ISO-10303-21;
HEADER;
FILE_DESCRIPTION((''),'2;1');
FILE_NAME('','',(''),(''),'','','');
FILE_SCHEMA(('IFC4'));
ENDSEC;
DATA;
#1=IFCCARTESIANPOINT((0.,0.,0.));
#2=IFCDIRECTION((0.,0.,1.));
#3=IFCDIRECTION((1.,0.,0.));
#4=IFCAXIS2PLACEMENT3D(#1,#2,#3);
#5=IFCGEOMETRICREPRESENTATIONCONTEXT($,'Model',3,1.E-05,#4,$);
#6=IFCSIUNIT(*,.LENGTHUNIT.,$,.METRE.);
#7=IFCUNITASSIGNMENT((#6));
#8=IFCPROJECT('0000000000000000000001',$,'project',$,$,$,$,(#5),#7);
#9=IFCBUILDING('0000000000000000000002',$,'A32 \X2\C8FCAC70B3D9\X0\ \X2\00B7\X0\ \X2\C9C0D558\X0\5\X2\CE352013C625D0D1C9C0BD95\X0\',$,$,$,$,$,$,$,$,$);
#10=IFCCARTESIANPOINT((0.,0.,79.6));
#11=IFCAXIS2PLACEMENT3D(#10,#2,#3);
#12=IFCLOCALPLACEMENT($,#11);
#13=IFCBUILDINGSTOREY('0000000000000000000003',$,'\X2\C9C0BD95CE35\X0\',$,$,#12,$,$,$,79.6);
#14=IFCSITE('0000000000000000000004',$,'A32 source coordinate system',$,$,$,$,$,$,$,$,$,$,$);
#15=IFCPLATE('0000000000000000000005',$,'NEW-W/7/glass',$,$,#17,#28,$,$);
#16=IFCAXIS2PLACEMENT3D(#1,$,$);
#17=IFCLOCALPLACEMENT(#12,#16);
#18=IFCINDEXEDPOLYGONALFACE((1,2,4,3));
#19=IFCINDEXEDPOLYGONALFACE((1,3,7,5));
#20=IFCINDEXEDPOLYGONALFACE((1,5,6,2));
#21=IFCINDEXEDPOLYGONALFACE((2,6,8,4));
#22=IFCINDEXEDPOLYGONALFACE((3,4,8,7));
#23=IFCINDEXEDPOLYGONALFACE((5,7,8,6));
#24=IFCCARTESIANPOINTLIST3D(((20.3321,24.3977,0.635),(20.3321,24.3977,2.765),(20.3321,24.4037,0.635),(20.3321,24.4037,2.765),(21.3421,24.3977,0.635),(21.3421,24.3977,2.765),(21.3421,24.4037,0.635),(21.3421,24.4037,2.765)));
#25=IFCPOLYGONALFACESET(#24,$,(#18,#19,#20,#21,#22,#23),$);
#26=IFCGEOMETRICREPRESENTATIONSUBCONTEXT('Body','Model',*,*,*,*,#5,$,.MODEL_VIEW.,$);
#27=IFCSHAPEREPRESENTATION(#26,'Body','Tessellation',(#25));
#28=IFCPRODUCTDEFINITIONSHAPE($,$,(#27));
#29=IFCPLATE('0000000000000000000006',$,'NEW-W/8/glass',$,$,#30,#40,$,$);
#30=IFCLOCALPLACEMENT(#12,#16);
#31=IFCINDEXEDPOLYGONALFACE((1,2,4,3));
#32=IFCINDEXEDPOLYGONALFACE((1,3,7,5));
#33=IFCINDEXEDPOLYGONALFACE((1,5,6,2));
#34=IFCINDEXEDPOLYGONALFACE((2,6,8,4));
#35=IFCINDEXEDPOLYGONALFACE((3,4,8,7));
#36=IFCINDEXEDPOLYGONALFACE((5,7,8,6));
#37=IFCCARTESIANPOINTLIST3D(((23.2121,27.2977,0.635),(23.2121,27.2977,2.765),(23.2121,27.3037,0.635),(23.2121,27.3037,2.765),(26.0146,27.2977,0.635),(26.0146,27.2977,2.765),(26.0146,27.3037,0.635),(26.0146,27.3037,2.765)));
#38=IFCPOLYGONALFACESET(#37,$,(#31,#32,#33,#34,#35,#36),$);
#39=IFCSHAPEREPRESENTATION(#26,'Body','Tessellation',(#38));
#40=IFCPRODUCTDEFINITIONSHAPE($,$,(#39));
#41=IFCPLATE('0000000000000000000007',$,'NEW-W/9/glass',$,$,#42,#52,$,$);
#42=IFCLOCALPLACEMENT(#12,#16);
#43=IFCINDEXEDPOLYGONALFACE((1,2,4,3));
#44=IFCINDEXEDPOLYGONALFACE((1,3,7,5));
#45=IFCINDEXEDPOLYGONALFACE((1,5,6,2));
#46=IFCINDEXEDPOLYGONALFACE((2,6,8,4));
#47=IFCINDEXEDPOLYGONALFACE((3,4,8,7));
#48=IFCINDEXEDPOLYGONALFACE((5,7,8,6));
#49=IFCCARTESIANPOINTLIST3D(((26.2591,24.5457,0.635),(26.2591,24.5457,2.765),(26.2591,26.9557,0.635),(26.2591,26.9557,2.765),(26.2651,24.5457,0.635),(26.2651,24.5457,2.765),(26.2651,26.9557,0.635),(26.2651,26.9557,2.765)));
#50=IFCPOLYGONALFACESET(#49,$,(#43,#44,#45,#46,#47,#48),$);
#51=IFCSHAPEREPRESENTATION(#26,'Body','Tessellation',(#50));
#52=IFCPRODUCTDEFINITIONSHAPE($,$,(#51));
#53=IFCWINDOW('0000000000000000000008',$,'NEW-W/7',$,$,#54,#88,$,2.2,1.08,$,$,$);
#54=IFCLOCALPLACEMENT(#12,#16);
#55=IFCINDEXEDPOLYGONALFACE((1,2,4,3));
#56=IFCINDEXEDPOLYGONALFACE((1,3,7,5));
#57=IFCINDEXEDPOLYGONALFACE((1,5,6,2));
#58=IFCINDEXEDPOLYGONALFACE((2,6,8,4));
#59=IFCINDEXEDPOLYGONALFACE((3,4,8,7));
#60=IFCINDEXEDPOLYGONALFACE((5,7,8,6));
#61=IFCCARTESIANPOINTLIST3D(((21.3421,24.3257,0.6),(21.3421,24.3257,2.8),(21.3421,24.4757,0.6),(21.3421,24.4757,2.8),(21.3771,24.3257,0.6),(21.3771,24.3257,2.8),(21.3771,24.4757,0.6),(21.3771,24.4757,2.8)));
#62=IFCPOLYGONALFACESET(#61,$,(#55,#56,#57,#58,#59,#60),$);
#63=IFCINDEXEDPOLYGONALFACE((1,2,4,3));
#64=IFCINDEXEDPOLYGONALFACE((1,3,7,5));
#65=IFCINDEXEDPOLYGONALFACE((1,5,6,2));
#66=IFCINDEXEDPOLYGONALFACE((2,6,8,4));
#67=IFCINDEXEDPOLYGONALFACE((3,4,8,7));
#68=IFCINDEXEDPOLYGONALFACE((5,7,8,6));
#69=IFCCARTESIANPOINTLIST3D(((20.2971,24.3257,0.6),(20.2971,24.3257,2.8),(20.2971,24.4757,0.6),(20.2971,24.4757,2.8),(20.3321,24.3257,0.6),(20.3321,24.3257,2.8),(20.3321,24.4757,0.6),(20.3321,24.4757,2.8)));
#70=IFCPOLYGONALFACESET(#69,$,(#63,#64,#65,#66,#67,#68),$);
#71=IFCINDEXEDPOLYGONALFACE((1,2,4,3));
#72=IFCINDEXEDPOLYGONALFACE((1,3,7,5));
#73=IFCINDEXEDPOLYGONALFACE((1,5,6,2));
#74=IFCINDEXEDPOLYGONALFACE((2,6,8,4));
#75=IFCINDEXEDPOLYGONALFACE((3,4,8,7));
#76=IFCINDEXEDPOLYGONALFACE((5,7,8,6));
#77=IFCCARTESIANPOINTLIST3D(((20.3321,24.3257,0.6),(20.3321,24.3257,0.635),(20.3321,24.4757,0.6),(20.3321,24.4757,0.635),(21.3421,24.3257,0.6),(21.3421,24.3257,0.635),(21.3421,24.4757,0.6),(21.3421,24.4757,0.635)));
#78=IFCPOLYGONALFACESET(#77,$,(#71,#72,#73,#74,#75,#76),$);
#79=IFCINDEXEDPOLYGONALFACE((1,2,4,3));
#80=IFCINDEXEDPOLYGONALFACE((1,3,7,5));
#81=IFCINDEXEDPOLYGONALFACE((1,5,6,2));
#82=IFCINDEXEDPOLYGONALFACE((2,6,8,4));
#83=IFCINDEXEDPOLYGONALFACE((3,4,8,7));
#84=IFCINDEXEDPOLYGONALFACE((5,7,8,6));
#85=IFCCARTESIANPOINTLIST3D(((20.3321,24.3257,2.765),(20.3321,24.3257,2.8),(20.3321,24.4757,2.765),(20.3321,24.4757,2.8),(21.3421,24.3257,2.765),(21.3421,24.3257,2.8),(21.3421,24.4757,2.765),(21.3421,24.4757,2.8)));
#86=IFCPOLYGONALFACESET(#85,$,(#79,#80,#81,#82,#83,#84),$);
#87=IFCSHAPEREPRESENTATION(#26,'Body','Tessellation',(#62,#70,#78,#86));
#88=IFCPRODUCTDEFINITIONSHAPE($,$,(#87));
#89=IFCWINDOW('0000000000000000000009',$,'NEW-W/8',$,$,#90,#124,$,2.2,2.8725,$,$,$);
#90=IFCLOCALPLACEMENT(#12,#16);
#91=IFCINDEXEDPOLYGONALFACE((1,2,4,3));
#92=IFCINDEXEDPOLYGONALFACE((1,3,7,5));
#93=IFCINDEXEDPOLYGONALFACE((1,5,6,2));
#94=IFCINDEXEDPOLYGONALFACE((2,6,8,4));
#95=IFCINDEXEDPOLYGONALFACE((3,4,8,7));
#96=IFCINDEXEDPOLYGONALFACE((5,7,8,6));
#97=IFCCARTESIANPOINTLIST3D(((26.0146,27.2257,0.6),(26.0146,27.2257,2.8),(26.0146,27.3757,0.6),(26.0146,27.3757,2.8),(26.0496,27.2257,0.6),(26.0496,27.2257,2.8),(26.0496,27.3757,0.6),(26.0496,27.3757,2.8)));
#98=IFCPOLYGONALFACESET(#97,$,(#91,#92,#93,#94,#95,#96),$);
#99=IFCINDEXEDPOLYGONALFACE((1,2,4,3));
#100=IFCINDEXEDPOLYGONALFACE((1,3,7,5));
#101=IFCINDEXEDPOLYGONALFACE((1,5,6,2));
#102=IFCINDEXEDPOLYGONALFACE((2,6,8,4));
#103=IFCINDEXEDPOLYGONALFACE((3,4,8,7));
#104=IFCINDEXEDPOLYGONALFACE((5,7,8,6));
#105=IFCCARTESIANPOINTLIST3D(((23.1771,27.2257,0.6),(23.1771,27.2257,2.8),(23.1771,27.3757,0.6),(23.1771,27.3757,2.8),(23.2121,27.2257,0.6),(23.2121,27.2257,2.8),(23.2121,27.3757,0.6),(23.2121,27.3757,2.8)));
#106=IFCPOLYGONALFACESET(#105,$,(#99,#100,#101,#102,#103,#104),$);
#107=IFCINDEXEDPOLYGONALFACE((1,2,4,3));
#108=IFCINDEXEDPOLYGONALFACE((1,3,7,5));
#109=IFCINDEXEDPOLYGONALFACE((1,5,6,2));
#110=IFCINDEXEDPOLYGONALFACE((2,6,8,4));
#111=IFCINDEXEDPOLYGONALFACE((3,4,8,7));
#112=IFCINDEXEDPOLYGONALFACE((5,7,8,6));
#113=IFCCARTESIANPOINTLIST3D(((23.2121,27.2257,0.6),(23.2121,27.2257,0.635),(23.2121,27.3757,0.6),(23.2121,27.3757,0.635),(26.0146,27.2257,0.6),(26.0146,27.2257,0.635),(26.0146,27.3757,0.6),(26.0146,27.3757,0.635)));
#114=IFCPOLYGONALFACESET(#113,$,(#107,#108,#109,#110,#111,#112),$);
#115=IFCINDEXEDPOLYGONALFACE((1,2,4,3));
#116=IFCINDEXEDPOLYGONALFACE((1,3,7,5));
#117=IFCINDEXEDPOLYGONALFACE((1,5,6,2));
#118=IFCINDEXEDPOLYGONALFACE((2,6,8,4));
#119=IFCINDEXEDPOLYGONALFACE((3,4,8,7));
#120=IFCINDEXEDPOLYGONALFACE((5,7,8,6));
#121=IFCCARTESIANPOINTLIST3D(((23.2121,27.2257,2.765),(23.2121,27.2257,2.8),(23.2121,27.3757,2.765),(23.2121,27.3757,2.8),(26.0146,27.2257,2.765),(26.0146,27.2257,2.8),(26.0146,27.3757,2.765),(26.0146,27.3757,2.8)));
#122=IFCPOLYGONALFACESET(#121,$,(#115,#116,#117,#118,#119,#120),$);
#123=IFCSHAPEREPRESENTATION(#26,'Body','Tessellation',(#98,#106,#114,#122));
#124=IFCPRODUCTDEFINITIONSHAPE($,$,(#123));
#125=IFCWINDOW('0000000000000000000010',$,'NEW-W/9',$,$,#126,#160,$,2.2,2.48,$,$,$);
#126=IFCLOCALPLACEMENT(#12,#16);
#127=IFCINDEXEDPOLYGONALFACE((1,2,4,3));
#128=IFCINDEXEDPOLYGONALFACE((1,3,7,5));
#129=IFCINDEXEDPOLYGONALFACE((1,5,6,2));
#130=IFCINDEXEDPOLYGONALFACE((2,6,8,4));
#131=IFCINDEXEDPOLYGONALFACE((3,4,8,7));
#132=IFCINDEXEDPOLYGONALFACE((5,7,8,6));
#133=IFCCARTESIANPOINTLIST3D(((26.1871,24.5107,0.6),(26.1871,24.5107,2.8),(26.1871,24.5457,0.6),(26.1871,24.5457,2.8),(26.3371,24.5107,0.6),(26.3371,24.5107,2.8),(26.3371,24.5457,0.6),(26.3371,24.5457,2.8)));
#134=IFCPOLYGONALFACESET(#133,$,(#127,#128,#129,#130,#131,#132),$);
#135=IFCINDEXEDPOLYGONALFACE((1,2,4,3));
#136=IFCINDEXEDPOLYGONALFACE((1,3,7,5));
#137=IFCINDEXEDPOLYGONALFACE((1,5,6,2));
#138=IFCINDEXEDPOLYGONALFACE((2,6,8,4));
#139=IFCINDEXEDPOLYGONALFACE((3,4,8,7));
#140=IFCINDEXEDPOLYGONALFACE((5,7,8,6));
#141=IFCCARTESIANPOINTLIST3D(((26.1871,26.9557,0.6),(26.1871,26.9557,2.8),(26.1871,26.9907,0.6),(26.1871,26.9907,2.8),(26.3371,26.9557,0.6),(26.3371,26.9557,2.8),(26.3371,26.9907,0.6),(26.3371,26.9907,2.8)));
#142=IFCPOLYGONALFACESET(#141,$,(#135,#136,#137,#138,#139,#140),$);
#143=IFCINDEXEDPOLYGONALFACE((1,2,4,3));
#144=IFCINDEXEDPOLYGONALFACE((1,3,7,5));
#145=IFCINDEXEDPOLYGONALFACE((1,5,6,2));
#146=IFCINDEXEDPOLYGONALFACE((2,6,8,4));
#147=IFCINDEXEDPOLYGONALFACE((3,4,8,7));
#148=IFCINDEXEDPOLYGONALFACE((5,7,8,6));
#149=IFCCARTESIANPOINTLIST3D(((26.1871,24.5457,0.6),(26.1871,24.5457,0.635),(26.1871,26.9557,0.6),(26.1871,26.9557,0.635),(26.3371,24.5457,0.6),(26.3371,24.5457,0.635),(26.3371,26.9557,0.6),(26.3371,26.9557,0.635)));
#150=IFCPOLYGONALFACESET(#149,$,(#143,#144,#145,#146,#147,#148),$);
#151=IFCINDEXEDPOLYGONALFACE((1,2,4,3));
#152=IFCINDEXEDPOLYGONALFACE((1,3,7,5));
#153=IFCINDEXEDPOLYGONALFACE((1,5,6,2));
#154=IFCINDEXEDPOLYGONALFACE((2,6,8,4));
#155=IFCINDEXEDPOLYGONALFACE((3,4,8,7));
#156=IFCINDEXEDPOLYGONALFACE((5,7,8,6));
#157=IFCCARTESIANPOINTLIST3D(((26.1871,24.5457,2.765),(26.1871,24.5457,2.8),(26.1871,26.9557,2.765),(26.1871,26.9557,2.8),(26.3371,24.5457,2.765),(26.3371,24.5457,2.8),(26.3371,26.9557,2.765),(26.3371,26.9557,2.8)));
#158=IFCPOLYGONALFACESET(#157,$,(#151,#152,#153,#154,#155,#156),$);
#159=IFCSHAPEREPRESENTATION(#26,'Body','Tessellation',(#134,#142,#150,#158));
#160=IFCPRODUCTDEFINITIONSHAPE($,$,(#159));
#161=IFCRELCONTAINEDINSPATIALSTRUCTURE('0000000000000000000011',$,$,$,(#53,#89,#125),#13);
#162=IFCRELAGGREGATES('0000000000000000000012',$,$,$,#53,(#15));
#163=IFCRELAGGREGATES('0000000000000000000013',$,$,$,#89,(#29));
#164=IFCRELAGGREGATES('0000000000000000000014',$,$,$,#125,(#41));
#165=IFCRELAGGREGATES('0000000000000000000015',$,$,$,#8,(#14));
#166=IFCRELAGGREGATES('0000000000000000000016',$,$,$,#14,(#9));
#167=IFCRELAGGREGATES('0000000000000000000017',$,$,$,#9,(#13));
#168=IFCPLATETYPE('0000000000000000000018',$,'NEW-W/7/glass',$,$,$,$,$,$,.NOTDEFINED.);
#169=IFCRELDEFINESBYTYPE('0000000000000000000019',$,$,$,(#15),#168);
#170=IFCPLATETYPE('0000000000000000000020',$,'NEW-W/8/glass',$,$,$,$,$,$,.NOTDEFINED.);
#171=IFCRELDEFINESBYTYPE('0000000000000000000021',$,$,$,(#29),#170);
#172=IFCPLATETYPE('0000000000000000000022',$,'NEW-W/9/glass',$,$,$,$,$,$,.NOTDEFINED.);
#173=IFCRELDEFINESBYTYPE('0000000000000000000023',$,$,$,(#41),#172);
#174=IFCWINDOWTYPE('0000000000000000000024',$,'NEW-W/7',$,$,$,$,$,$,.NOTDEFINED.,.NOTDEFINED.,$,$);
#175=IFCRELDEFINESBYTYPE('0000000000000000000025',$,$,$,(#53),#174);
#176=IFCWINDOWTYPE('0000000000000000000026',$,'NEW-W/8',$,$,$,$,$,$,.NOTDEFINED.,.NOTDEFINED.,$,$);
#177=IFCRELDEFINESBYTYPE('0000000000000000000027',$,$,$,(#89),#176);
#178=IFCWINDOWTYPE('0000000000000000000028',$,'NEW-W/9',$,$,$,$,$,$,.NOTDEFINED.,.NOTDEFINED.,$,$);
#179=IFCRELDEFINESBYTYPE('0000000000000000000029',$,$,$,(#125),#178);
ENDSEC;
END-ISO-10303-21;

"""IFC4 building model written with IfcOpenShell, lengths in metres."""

from ifc_helpers import new_model, si_unit, frame, origin, origin_with_axes, place, context, subcontext, project, spatial, polyline, outline, extrude, source, transform, mapped, type_object, type_shapes, element, aggregate, save


model = new_model("IFC4")

# Units and contexts
model_context = context("Model", 3, precision=1e-05, world=origin_with_axes())
body_context = subcontext(model_context, "Body", "Model", "MODEL_VIEW")
ifc_project = project(units=[si_unit("LENGTHUNIT", "METRE")], contexts=[model_context])

# Site, building, storey
site = spatial("IfcSite", under=ifc_project, Name="A32 source coordinate system")
building = spatial("IfcBuilding", under=site, Name="A32 주거동 · 지하5층–옥탑지붕")
storey_placement = place(None, frame((0.0, 0.0, 79.6), z_axis=(0.0, 0.0, 1.0), x_axis=(1.0, 0.0, 0.0)))
storey = spatial("IfcBuildingStorey", under=building, at=storey_placement, Name="지붕층", Elevation=79.6)

# Plates
plate_type_1 = type_object("IfcPlateType", Name="NEW-W/7/glass", PredefinedType="NOTDEFINED")
shared_shape_1 = source(origin(), body_context, "Body", "SweptSolid", [
    extrude(outline(polyline([(21.3421, 24.3977), (20.3321, 24.3977), (20.3321, 24.4037), (21.3421, 24.4037), (21.3421, 24.3977)])), frame((0.0, 0.0, 0.635)), (0.0, 0.0, 1.0), 2.13),
])
type_shapes(plate_type_1, [shared_shape_1])
window_1_placement = place(storey_placement, origin_with_axes())
plate_1_placement = place(window_1_placement, origin_with_axes())
plate_1 = element("IfcPlate", 1, at=plate_1_placement, type_object=plate_type_1, Name="NEW-W/7/glass", context=body_context, shape_type="MappedRepresentation", body=[
    mapped(shared_shape_1, transform((0.0, 0.0, 0.0), scale=1.0)),
])
plate_type_2 = type_object("IfcPlateType", Name="NEW-W/8/glass", PredefinedType="NOTDEFINED")
shared_shape_2 = source(origin(), body_context, "Body", "SweptSolid", [
    extrude(outline(polyline([(26.0146, 27.2977), (23.2121, 27.2977), (23.2121, 27.3037), (26.0146, 27.3037), (26.0146, 27.2977)])), frame((0.0, 0.0, 0.635)), (0.0, 0.0, 1.0), 2.13),
])
type_shapes(plate_type_2, [shared_shape_2])
window_2_placement = place(storey_placement, origin_with_axes())
plate_2_placement = place(window_2_placement, origin_with_axes())
plate_2 = element("IfcPlate", 2, at=plate_2_placement, type_object=plate_type_2, Name="NEW-W/8/glass", context=body_context, shape_type="MappedRepresentation", body=[
    mapped(shared_shape_2, transform((0.0, 0.0, 0.0), scale=1.0)),
])
plate_type_3 = type_object("IfcPlateType", Name="NEW-W/9/glass", PredefinedType="NOTDEFINED")
shared_shape_3 = source(origin(), body_context, "Body", "SweptSolid", [
    extrude(outline(polyline([(26.2651, 24.5457), (26.2591, 24.5457), (26.2591, 26.9557), (26.2651, 26.9557), (26.2651, 24.5457)])), frame((0.0, 0.0, 0.635)), (0.0, 0.0, 1.0), 2.13),
])
type_shapes(plate_type_3, [shared_shape_3])
window_3_placement = place(storey_placement, origin_with_axes())
plate_3_placement = place(window_3_placement, origin_with_axes())
plate_3 = element("IfcPlate", 3, at=plate_3_placement, type_object=plate_type_3, Name="NEW-W/9/glass", context=body_context, shape_type="MappedRepresentation", body=[
    mapped(shared_shape_3, transform((0.0, 0.0, 0.0), scale=1.0)),
])

# Windows
window_type_1 = type_object("IfcWindowType", Name="NEW-W/7", PartitioningType="NOTDEFINED", PredefinedType="NOTDEFINED")
shared_shape_4 = source(origin(), body_context, "Body", "SweptSolid", [
    extrude(outline(polyline([(21.3421, 24.3257), (21.3421, 24.4757), (21.3771, 24.4757), (21.3771, 24.3257), (21.3421, 24.3257)])), frame((0.0, 0.0, 0.6)), (0.0, 0.0, 1.0), 2.2),
    extrude(outline(polyline([(20.2971, 24.3257), (20.2971, 24.4757), (20.3321, 24.4757), (20.3321, 24.3257), (20.2971, 24.3257)])), frame((0.0, 0.0, 0.6)), (0.0, 0.0, 1.0), 2.2),
    extrude(outline(polyline([(21.3421, 24.3257), (21.3421, 24.4757), (20.3321, 24.4757), (20.3321, 24.3257), (21.3421, 24.3257)])), frame((0.0, 0.0, 0.6)), (0.0, 0.0, 1.0), 0.035),
    extrude(outline(polyline([(21.3421, 24.3257), (21.3421, 24.4757), (20.3321, 24.4757), (20.3321, 24.3257), (21.3421, 24.3257)])), frame((0.0, 0.0, 2.765)), (0.0, 0.0, 1.0), 0.035),
])
type_shapes(window_type_1, [shared_shape_4])
window_1 = element("IfcWindow", 4, at=window_1_placement, inside=storey, type_object=window_type_1, Name="NEW-W/7", OverallHeight=2.2, OverallWidth=1.08, context=body_context, shape_type="MappedRepresentation", body=[
    mapped(shared_shape_4, transform((0.0, 0.0, 0.0), scale=1.0)),
])
aggregate(window_1, [plate_1])
window_type_2 = type_object("IfcWindowType", Name="NEW-W/8", PartitioningType="NOTDEFINED", PredefinedType="NOTDEFINED")
shared_shape_5 = source(origin(), body_context, "Body", "SweptSolid", [
    extrude(outline(polyline([(26.0146, 27.2257), (26.0146, 27.3757), (26.0496, 27.3757), (26.0496, 27.2257), (26.0146, 27.2257)])), frame((0.0, 0.0, 0.6)), (0.0, 0.0, 1.0), 2.2),
    extrude(outline(polyline([(23.1771, 27.2257), (23.1771, 27.3757), (23.2121, 27.3757), (23.2121, 27.2257), (23.1771, 27.2257)])), frame((0.0, 0.0, 0.6)), (0.0, 0.0, 1.0), 2.2),
    extrude(outline(polyline([(26.0146, 27.2257), (26.0146, 27.3757), (23.2121, 27.3757), (23.2121, 27.2257), (26.0146, 27.2257)])), frame((0.0, 0.0, 0.6)), (0.0, 0.0, 1.0), 0.035),
    extrude(outline(polyline([(26.0146, 27.2257), (26.0146, 27.3757), (23.2121, 27.3757), (23.2121, 27.2257), (26.0146, 27.2257)])), frame((0.0, 0.0, 2.765)), (0.0, 0.0, 1.0), 0.035),
])
type_shapes(window_type_2, [shared_shape_5])
window_2 = element("IfcWindow", 5, at=window_2_placement, inside=storey, type_object=window_type_2, Name="NEW-W/8", OverallHeight=2.2, OverallWidth=2.8725, context=body_context, shape_type="MappedRepresentation", body=[
    mapped(shared_shape_5, transform((0.0, 0.0, 0.0), scale=1.0)),
])
aggregate(window_2, [plate_2])
window_type_3 = type_object("IfcWindowType", Name="NEW-W/9", PartitioningType="NOTDEFINED", PredefinedType="NOTDEFINED")
shared_shape_6 = source(origin(), body_context, "Body", "SweptSolid", [
    extrude(outline(polyline([(26.1871, 24.5107), (26.1871, 24.5457), (26.3371, 24.5457), (26.3371, 24.5107), (26.1871, 24.5107)])), frame((0.0, 0.0, 0.6)), (0.0, 0.0, 1.0), 2.2),
    extrude(outline(polyline([(26.1871, 26.9557), (26.1871, 26.9907), (26.3371, 26.9907), (26.3371, 26.9557), (26.1871, 26.9557)])), frame((0.0, 0.0, 0.6)), (0.0, 0.0, 1.0), 2.2),
    extrude(outline(polyline([(26.3371, 24.5457), (26.3371, 26.9557), (26.1871, 26.9557), (26.1871, 24.5457), (26.3371, 24.5457)])), frame((0.0, 0.0, 0.6)), (0.0, 0.0, 1.0), 0.035),
    extrude(outline(polyline([(26.3371, 24.5457), (26.3371, 26.9557), (26.1871, 26.9557), (26.1871, 24.5457), (26.3371, 24.5457)])), frame((0.0, 0.0, 2.765)), (0.0, 0.0, 1.0), 0.035),
])
type_shapes(window_type_3, [shared_shape_6])
window_3 = element("IfcWindow", 6, at=window_3_placement, inside=storey, type_object=window_type_3, Name="NEW-W/9", OverallHeight=2.2, OverallWidth=2.48, context=body_context, shape_type="MappedRepresentation", body=[
    mapped(shared_shape_6, transform((0.0, 0.0, 0.0), scale=1.0)),
])
aggregate(window_3, [plate_3])

save(model, "model.ifc")
